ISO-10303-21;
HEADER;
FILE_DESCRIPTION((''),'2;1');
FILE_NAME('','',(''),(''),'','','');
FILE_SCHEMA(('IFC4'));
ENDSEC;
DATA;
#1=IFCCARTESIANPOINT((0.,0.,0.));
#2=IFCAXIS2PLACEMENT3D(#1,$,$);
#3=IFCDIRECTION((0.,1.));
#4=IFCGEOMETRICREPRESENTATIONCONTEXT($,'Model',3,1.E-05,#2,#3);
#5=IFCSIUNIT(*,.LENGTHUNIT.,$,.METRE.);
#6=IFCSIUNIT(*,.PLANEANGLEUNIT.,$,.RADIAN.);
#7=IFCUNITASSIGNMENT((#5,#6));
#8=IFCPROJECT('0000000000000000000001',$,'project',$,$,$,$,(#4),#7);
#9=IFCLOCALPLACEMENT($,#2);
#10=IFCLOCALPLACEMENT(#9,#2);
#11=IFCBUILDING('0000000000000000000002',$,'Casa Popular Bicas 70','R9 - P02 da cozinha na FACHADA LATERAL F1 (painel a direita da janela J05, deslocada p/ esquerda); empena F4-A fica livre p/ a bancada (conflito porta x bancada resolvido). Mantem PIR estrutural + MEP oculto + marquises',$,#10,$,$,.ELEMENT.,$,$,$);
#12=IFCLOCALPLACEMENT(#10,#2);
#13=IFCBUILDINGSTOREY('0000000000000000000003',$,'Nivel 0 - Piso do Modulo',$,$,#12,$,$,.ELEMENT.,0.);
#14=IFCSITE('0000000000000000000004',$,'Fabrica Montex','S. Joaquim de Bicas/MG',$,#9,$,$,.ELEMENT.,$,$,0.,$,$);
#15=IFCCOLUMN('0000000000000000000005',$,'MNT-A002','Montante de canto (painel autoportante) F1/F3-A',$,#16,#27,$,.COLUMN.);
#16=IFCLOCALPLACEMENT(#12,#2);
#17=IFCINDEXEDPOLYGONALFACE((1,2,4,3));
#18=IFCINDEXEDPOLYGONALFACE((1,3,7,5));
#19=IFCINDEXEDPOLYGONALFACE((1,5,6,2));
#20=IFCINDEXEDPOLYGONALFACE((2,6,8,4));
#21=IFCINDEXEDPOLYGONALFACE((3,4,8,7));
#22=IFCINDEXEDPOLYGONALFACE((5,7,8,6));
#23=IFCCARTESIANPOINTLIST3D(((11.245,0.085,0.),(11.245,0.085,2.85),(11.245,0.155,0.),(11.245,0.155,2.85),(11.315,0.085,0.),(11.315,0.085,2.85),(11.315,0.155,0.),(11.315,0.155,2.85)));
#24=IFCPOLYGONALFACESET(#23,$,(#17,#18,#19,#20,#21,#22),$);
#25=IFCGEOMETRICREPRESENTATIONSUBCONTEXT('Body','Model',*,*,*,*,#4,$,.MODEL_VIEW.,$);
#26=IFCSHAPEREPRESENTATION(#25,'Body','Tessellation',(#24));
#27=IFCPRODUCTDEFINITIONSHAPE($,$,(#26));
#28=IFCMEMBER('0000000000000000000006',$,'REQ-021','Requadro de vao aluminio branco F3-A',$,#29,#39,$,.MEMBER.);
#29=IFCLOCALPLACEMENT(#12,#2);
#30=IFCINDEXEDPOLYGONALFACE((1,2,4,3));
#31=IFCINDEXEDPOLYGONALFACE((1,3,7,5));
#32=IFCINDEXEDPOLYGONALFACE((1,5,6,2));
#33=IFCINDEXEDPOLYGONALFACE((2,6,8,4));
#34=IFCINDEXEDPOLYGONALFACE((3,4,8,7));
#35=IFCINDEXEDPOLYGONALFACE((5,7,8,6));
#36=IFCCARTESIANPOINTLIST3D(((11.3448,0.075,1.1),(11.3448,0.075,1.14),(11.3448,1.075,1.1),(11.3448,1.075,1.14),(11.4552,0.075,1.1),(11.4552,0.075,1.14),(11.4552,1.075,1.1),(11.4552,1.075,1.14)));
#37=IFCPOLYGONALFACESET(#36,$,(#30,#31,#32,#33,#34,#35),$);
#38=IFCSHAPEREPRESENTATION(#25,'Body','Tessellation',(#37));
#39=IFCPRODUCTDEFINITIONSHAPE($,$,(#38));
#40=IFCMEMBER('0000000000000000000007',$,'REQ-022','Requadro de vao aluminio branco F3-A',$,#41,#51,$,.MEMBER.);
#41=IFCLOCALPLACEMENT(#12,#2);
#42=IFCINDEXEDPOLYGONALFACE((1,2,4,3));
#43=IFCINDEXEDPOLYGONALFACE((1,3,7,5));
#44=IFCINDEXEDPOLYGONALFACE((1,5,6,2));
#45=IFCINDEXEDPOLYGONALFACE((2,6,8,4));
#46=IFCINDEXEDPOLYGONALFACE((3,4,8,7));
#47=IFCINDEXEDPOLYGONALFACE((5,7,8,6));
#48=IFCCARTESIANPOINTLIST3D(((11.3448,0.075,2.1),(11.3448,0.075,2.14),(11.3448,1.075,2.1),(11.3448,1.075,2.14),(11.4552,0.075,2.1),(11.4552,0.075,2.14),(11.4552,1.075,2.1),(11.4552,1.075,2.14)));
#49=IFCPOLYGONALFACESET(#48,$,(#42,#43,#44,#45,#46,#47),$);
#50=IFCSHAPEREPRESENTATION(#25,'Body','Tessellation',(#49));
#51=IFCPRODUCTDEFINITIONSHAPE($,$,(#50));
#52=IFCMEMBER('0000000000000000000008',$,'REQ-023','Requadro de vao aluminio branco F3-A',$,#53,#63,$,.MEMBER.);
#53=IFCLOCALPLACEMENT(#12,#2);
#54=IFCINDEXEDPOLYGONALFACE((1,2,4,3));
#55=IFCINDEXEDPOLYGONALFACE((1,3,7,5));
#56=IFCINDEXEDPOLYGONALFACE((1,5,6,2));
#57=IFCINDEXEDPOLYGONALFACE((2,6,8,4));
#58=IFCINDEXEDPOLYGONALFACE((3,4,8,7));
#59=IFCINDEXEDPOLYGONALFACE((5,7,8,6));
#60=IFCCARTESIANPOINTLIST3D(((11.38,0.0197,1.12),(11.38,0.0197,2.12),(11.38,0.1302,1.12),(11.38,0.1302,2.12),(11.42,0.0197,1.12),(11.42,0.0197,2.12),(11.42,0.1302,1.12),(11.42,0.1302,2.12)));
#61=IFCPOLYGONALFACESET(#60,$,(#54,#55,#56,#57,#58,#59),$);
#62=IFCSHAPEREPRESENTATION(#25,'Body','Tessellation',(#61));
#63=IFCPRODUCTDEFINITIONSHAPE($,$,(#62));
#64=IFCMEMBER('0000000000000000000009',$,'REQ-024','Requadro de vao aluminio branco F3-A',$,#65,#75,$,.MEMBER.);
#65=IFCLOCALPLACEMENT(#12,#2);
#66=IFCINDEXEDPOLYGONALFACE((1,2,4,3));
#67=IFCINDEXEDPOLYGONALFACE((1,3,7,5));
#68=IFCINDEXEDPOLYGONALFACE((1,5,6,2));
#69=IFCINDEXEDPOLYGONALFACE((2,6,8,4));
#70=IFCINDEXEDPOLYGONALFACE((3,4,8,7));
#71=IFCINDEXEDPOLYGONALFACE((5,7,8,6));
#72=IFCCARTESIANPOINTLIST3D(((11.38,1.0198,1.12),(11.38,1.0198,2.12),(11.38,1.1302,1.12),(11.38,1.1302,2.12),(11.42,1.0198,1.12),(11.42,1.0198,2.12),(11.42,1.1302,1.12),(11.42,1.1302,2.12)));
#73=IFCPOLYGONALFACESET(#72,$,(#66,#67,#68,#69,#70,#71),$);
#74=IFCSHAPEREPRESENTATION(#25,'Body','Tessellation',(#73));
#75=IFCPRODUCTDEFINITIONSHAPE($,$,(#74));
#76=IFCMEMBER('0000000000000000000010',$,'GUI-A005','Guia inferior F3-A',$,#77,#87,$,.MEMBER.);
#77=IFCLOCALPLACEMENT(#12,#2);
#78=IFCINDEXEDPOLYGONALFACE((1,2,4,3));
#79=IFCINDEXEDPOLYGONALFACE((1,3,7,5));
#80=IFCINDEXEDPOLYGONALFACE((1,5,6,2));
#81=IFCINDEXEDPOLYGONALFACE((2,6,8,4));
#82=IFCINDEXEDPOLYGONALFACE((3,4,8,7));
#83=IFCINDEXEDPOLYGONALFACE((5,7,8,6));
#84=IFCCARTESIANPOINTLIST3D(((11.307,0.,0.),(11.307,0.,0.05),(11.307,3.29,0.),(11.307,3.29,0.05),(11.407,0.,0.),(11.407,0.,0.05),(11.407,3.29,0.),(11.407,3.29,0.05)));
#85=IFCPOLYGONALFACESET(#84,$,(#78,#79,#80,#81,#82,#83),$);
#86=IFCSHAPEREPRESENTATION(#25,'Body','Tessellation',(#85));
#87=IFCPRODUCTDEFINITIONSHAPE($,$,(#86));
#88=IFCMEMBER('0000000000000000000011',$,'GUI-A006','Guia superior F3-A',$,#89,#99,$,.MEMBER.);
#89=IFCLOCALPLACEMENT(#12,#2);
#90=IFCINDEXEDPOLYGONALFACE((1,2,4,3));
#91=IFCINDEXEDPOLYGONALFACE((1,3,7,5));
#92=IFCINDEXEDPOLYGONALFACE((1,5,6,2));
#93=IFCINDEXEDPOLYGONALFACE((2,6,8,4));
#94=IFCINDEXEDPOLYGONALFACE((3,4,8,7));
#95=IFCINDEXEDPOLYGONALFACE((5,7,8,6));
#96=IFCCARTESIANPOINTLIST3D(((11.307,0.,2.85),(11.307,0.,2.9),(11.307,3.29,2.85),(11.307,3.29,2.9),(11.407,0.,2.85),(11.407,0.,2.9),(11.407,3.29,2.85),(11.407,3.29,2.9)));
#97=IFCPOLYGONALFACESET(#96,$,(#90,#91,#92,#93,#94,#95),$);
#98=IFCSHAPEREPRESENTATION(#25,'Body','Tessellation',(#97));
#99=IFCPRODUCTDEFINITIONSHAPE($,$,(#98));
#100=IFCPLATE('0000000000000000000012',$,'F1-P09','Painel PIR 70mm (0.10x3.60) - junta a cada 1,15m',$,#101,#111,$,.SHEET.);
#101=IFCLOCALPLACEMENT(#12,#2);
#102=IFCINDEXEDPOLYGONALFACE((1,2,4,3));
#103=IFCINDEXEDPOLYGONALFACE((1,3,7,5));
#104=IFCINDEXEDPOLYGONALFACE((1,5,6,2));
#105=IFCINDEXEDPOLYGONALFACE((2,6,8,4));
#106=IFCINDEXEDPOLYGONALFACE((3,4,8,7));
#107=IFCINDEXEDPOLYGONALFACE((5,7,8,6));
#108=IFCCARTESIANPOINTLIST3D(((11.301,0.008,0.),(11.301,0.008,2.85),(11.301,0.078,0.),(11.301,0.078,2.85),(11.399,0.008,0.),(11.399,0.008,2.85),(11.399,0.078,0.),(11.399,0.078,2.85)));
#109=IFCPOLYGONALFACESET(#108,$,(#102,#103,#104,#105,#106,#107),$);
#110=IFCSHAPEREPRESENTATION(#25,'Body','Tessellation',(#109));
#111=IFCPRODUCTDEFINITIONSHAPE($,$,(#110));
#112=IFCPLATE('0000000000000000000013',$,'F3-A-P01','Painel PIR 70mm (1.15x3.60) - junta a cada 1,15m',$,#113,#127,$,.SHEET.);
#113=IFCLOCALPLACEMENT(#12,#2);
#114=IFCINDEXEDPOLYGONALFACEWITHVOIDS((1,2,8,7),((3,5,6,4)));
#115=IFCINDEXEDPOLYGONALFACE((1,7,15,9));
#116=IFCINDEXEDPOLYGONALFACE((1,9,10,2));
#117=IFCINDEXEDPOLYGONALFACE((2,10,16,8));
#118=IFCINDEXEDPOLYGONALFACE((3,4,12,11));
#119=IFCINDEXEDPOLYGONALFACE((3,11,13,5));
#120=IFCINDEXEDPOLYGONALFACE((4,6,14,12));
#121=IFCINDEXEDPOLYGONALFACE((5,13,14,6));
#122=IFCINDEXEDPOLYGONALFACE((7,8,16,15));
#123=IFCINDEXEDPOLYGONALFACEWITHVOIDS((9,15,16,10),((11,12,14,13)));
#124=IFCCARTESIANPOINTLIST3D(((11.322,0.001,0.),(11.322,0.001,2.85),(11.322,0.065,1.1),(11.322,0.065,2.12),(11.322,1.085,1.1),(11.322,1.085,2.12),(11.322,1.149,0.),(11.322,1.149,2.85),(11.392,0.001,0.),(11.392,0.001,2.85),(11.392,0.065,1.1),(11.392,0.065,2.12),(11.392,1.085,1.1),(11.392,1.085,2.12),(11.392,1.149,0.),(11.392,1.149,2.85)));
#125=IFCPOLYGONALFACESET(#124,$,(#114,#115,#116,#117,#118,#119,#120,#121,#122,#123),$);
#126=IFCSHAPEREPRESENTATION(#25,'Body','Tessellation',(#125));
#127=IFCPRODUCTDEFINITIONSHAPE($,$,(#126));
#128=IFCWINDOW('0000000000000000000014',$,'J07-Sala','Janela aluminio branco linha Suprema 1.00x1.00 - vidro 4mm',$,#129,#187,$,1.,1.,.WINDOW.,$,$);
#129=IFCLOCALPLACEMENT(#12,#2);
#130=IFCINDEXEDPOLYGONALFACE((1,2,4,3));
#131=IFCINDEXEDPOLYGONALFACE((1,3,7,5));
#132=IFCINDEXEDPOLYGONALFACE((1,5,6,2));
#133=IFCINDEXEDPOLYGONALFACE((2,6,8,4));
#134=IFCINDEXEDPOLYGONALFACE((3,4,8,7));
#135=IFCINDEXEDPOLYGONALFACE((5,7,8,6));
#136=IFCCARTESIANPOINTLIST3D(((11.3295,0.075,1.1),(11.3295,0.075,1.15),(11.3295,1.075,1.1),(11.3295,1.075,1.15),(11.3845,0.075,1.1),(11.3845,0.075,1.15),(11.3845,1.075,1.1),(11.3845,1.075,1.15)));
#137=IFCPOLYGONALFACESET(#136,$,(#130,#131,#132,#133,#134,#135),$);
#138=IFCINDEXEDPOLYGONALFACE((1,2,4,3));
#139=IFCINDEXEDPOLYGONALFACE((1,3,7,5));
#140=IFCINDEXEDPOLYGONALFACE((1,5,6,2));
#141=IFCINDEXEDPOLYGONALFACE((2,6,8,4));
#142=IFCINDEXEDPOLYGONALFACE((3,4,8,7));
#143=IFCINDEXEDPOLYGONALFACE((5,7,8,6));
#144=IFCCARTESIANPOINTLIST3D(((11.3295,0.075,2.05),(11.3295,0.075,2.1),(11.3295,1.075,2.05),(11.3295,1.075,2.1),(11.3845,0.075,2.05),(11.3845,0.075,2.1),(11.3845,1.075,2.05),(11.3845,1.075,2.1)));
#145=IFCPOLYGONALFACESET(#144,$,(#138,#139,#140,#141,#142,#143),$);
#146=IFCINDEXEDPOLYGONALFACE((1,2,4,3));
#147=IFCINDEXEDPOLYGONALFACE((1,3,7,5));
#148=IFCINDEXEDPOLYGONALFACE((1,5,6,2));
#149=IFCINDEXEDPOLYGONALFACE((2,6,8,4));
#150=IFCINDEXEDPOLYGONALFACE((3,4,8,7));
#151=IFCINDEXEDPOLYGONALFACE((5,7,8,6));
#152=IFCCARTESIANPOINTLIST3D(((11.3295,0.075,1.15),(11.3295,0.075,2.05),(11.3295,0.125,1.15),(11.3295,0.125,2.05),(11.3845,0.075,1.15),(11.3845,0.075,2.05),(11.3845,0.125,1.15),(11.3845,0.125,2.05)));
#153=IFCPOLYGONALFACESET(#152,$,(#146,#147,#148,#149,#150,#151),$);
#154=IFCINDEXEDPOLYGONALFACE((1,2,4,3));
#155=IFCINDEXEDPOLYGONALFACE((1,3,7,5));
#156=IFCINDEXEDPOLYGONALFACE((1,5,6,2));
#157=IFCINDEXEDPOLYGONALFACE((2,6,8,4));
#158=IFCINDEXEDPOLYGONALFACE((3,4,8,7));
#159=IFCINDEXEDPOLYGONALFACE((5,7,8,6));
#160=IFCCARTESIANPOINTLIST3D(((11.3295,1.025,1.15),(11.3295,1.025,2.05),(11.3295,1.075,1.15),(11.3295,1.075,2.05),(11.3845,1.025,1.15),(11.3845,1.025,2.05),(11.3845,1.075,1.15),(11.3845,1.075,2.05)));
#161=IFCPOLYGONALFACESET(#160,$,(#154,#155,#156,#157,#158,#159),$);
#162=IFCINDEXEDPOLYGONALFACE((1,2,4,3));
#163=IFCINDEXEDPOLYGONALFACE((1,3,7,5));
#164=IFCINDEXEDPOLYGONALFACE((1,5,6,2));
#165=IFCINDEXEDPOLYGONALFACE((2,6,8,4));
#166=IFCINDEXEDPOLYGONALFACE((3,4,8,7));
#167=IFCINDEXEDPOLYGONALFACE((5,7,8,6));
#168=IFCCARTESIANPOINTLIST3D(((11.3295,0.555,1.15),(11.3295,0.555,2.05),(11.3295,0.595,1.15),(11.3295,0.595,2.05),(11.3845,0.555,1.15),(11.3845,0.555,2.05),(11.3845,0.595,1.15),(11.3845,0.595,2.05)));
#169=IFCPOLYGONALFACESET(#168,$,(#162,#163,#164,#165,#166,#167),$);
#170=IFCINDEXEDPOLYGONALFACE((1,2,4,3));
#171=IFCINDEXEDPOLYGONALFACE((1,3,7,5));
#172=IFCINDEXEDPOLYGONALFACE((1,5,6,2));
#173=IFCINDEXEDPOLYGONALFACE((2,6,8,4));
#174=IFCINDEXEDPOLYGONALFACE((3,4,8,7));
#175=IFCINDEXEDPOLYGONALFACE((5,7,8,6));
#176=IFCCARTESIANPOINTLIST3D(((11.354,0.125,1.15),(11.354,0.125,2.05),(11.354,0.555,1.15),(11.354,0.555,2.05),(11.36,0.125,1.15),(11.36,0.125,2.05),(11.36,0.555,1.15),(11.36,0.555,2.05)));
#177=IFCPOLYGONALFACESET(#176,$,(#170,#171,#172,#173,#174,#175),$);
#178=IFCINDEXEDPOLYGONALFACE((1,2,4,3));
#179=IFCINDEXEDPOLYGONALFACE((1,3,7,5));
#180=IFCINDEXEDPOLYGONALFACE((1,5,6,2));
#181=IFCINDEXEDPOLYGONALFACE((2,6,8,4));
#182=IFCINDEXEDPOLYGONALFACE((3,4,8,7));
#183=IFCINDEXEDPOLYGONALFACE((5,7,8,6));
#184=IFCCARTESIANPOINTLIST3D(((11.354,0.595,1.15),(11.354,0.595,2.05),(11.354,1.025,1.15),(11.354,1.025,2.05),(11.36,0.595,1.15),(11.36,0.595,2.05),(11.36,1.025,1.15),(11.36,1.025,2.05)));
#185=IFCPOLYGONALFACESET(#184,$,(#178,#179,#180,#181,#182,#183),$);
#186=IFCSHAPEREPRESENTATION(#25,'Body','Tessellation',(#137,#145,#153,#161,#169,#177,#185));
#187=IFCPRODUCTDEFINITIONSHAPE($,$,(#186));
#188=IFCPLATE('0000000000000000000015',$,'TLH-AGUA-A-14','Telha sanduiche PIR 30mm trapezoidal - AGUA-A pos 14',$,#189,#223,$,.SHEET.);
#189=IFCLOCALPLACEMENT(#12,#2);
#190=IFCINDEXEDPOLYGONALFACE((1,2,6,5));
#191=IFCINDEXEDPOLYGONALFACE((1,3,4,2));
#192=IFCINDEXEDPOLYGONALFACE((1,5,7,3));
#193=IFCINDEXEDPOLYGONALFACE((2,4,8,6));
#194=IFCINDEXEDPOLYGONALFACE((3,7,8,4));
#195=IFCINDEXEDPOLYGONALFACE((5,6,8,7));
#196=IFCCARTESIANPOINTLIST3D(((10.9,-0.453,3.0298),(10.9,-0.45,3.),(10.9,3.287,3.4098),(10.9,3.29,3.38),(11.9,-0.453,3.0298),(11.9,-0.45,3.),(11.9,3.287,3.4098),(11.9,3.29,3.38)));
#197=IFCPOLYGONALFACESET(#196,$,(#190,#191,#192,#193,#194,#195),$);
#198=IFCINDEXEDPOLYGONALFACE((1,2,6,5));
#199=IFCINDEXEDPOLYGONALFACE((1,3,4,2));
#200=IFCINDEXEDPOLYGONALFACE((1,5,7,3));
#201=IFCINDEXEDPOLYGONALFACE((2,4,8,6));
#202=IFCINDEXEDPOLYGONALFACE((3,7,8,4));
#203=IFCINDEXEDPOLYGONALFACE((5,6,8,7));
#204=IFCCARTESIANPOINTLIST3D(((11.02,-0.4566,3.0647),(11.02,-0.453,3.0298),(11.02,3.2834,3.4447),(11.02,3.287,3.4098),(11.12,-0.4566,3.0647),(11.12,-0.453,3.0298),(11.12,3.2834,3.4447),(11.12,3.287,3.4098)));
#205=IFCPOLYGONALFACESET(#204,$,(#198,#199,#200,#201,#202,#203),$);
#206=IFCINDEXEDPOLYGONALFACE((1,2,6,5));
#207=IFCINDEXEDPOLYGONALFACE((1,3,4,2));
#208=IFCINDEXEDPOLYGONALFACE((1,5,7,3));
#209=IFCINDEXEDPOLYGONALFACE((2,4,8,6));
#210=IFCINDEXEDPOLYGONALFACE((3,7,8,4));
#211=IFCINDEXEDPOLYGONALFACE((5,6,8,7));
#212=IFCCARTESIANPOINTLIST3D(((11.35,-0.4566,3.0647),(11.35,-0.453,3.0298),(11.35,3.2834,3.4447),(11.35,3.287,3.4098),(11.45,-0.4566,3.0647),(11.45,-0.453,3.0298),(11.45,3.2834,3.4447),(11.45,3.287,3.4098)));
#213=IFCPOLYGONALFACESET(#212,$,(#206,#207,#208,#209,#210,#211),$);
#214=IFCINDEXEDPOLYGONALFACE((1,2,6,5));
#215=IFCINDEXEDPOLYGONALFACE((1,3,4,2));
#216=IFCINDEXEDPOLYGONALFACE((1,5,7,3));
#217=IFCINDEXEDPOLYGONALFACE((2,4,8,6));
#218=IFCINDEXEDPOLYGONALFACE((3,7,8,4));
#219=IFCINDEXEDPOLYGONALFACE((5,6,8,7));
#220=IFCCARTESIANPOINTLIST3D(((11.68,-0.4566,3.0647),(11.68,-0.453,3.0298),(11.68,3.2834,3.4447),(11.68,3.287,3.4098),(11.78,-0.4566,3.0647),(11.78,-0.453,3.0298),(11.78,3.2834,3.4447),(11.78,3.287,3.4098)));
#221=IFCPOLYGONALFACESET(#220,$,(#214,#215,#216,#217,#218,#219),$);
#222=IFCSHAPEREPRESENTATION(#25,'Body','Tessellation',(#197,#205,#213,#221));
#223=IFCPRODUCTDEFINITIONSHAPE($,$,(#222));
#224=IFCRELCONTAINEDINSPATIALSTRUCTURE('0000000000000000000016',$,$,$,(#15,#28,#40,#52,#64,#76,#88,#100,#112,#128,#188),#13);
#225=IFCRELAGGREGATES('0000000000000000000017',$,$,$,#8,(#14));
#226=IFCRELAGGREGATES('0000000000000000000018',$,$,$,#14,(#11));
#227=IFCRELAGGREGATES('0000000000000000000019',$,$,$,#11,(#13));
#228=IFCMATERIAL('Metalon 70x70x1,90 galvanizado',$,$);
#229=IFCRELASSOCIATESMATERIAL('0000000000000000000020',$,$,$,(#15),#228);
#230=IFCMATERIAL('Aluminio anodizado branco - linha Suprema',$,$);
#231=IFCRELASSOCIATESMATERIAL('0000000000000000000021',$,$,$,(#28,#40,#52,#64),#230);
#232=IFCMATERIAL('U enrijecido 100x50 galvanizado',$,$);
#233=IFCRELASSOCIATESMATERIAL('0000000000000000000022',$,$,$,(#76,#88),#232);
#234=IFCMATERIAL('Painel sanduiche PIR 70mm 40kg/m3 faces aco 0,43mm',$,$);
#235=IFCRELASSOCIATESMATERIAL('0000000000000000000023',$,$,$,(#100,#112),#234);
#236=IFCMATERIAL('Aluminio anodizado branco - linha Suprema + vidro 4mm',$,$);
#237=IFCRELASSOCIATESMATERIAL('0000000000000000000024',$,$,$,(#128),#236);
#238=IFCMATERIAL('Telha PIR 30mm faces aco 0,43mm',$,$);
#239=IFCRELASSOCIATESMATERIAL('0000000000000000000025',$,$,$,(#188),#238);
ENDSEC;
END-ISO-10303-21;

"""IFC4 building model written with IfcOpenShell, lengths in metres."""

from ifc_helpers import new_model, si_unit, direction, frame, frame_2d, origin, origin_2d, place, context, subcontext, project, spatial, rectangle, extrude, material, element, fill, save


model = new_model("IFC4")

# Units and contexts
model_context = context("Model", 3, precision=1e-05, world=origin(), true_north=direction((0.0, 1.0)))
body_context = subcontext(model_context, "Body", "Model", "MODEL_VIEW")
ifc_project = project(units=[si_unit("LENGTHUNIT", "METRE"), si_unit("PLANEANGLEUNIT", "RADIAN")], contexts=[model_context])

# Site, building, storey
site_placement = place(None, origin())
site = spatial("IfcSite", under=ifc_project, at=site_placement, Name="Fabrica Montex", Description="S. Joaquim de Bicas/MG", CompositionType="ELEMENT", RefElevation=0.0)
building_placement = place(site_placement, origin())
building = spatial("IfcBuilding", under=site, at=building_placement, Name="Casa Popular Bicas 70", Description="R9 - P02 da cozinha na FACHADA LATERAL F1 (painel a direita da janela J05, deslocada p/ esquerda); empena F4-A fica livre p/ a bancada (conflito porta x bancada resolvido). Mantem PIR estrutural + MEP oculto + marquises", CompositionType="ELEMENT")
storey_placement = place(building_placement, origin())
storey = spatial("IfcBuildingStorey", under=building, at=storey_placement, Name="Nivel 0 - Piso do Modulo", CompositionType="ELEMENT", Elevation=0.0)

# Column
ifc_material_1 = material(Name="Metalon 70x70x1,90 galvanizado")
column_placement = place(storey_placement, frame((11.28, 0.12, 0.0)))
element("IfcColumn", 1, at=column_placement, inside=storey, material=ifc_material_1, Name="MNT-A002", Description="Montante de canto (painel autoportante) F1/F3-A", PredefinedType="COLUMN", context=body_context, shape_type="SweptSolid", body=[
    extrude(rectangle(XDim=0.07, YDim=0.07, at=origin_2d()), origin(), (0.0, 0.0, 1.0), 2.85),
])

# Members
ifc_material_2 = material(Name="Aluminio anodizado branco - linha Suprema")
for number, where, z_axis, x_axis, name in (
    (2, (11.4, 0.075, 1.12), (0.0, 1.0, 0.0), (0.0, 0.0, 1.0), "REQ-021"),
    (3, (11.4, 0.075, 2.12), (0.0, 1.0, 0.0), (0.0, 0.0, 1.0), "REQ-022"),
    (4, (11.4, 0.075, 1.12), (0.0, 0.0, 1.0), (1.0, 0.0, 0.0), "REQ-023"),
    (5, (11.4, 1.075, 1.12), (0.0, 0.0, 1.0), (1.0, 0.0, 0.0), "REQ-024"),
):
    element("IfcMember", number, at=place(storey_placement, frame(where, z_axis=z_axis, x_axis=x_axis)), inside=storey, material=ifc_material_2, Name=name, Description="Requadro de vao aluminio branco F3-A", PredefinedType="MEMBER", context=body_context, shape_type="SweptSolid", body=[
        extrude(rectangle(XDim=0.04, YDim=0.1105, at=origin_2d()), origin(), (0.0, 0.0, 1.0), 1.0),
    ])
ifc_material_3 = material(Name="U enrijecido 100x50 galvanizado")
for number, where, z_axis, x_axis, name, description in (
    (6, (11.357, 0.0, 0.025), (0.0, 1.0, 0.0), (0.0, 0.0, 1.0), "GUI-A005", "Guia inferior F3-A"),
    (7, (11.357, 0.0, 2.875), (0.0, 1.0, 0.0), (0.0, 0.0, 1.0), "GUI-A006", "Guia superior F3-A"),
):
    element("IfcMember", number, at=place(storey_placement, frame(where, z_axis=z_axis, x_axis=x_axis)), inside=storey, material=ifc_material_3, Name=name, Description=description, PredefinedType="MEMBER", context=body_context, shape_type="SweptSolid", body=[
        extrude(rectangle(XDim=0.05, YDim=0.1, at=origin_2d()), origin(), (0.0, 0.0, 1.0), 3.29),
    ])

# Plate
ifc_material_4 = material(Name="Painel sanduiche PIR 70mm 40kg/m3 faces aco 0,43mm")
plate_1_placement = place(storey_placement, frame((11.301, 0.043, 0.0), x_axis=(1.0, 0.0, 0.0)))
element("IfcPlate", 8, at=plate_1_placement, inside=storey, material=ifc_material_4, Name="F1-P09", Description="Painel PIR 70mm (0.10x3.60) - junta a cada 1,15m", PredefinedType="SHEET", context=body_context, shape_type="SweptSolid", body=[
    extrude(rectangle(XDim=0.098, YDim=0.07, at=frame_2d((0.049, 0.0))), origin(), (0.0, 0.0, 1.0), 2.85),
])

# Plate, opening, window
plate_2_placement = place(storey_placement, frame((11.357, 0.001, 0.0), x_axis=(0.0, 1.0, 0.0)))
plate_2 = element("IfcPlate", 9, at=plate_2_placement, inside=storey, material=ifc_material_4, Name="F3-A-P01", Description="Painel PIR 70mm (1.15x3.60) - junta a cada 1,15m", PredefinedType="SHEET", context=body_context, shape_type="SweptSolid", body=[
    extrude(rectangle(XDim=1.148, YDim=0.07, at=frame_2d((0.574, 0.0))), origin(), (0.0, 0.0, 1.0), 2.85),
])
opening_1_placement = place(storey_placement, frame((11.357, 0.075, 1.1), x_axis=(0.0, 1.0, 0.0)))
opening_1 = element("IfcOpeningElement", 10, at=opening_1_placement, cuts=plate_2, PredefinedType="OPENING", context=body_context, shape_type="SweptSolid", body=[
    extrude(rectangle(XDim=1.02, YDim=0.3, at=frame_2d((0.5, 0.0))), origin(), (0.0, 0.0, 1.0), 1.02),
])
ifc_material_5 = material(Name="Aluminio anodizado branco - linha Suprema + vidro 4mm")
window_placement = place(storey_placement, frame((11.357, 0.075, 1.1), x_axis=(0.0, 1.0, 0.0)))
window = element("IfcWindow", 11, at=window_placement, inside=storey, material=ifc_material_5, Name="J07-Sala", Description="Janela aluminio branco linha Suprema 1.00x1.00 - vidro 4mm", OverallHeight=1.0, OverallWidth=1.0, PredefinedType="WINDOW", context=body_context, shape_type="SweptSolid", body=[
    extrude(rectangle(XDim=1.0, YDim=0.055, at=frame_2d((0.5, 0.0))), origin(), (0.0, 0.0, 1.0), 0.05),
    extrude(rectangle(XDim=1.0, YDim=0.055, at=frame_2d((0.5, 0.0))), frame((0.0, 0.0, 0.95)), (0.0, 0.0, 1.0), 0.05),
    extrude(rectangle(XDim=0.05, YDim=0.055, at=frame_2d((0.025, 0.0))), frame((0.0, 0.0, 0.05)), (0.0, 0.0, 1.0), 0.9),
    extrude(rectangle(XDim=0.05, YDim=0.055, at=frame_2d((0.975, 0.0))), frame((0.0, 0.0, 0.05)), (0.0, 0.0, 1.0), 0.9),
    extrude(rectangle(XDim=0.04, YDim=0.055, at=frame_2d((0.5, 0.0))), frame((0.0, 0.0, 0.05)), (0.0, 0.0, 1.0), 0.9),
    extrude(rectangle(XDim=0.43, YDim=0.006, at=frame_2d((0.265, 0.0))), frame((0.0, 0.0, 0.05)), (0.0, 0.0, 1.0), 0.9),
    extrude(rectangle(XDim=0.43, YDim=0.006, at=frame_2d((0.735, 0.0))), frame((0.0, 0.0, 0.05)), (0.0, 0.0, 1.0), 0.9),
])
fill(opening_1, window)

# Plate
ifc_material_6 = material(Name="Telha PIR 30mm faces aco 0,43mm")
plate_3_placement = place(storey_placement, frame((10.9, -0.45, 3.0), z_axis=(0.0, -0.101084, 0.994878), x_axis=(1.0, 0.0, 0.0)))
element("IfcPlate", 12, at=plate_3_placement, inside=storey, material=ifc_material_6, Name="TLH-AGUA-A-14", Description="Telha sanduiche PIR 30mm trapezoidal - AGUA-A pos 14", PredefinedType="SHEET", context=body_context, shape_type="SweptSolid", body=[
    extrude(rectangle(XDim=1.0, YDim=3.7593, at=frame_2d((0.5, 1.8796))), origin(), (0.0, 0.0, 1.0), 0.03),
    extrude(rectangle(XDim=0.1, YDim=3.7593, at=frame_2d((0.17, 1.8796))), frame((0.0, 0.0, 0.03)), (0.0, 0.0, 1.0), 0.035),
    extrude(rectangle(XDim=0.1, YDim=3.7593, at=frame_2d((0.5, 1.8796))), frame((0.0, 0.0, 0.03)), (0.0, 0.0, 1.0), 0.035),
    extrude(rectangle(XDim=0.1, YDim=3.7593, at=frame_2d((0.83, 1.8796))), frame((0.0, 0.0, 0.03)), (0.0, 0.0, 1.0), 0.035),
])

save(model, "model.ifc")
